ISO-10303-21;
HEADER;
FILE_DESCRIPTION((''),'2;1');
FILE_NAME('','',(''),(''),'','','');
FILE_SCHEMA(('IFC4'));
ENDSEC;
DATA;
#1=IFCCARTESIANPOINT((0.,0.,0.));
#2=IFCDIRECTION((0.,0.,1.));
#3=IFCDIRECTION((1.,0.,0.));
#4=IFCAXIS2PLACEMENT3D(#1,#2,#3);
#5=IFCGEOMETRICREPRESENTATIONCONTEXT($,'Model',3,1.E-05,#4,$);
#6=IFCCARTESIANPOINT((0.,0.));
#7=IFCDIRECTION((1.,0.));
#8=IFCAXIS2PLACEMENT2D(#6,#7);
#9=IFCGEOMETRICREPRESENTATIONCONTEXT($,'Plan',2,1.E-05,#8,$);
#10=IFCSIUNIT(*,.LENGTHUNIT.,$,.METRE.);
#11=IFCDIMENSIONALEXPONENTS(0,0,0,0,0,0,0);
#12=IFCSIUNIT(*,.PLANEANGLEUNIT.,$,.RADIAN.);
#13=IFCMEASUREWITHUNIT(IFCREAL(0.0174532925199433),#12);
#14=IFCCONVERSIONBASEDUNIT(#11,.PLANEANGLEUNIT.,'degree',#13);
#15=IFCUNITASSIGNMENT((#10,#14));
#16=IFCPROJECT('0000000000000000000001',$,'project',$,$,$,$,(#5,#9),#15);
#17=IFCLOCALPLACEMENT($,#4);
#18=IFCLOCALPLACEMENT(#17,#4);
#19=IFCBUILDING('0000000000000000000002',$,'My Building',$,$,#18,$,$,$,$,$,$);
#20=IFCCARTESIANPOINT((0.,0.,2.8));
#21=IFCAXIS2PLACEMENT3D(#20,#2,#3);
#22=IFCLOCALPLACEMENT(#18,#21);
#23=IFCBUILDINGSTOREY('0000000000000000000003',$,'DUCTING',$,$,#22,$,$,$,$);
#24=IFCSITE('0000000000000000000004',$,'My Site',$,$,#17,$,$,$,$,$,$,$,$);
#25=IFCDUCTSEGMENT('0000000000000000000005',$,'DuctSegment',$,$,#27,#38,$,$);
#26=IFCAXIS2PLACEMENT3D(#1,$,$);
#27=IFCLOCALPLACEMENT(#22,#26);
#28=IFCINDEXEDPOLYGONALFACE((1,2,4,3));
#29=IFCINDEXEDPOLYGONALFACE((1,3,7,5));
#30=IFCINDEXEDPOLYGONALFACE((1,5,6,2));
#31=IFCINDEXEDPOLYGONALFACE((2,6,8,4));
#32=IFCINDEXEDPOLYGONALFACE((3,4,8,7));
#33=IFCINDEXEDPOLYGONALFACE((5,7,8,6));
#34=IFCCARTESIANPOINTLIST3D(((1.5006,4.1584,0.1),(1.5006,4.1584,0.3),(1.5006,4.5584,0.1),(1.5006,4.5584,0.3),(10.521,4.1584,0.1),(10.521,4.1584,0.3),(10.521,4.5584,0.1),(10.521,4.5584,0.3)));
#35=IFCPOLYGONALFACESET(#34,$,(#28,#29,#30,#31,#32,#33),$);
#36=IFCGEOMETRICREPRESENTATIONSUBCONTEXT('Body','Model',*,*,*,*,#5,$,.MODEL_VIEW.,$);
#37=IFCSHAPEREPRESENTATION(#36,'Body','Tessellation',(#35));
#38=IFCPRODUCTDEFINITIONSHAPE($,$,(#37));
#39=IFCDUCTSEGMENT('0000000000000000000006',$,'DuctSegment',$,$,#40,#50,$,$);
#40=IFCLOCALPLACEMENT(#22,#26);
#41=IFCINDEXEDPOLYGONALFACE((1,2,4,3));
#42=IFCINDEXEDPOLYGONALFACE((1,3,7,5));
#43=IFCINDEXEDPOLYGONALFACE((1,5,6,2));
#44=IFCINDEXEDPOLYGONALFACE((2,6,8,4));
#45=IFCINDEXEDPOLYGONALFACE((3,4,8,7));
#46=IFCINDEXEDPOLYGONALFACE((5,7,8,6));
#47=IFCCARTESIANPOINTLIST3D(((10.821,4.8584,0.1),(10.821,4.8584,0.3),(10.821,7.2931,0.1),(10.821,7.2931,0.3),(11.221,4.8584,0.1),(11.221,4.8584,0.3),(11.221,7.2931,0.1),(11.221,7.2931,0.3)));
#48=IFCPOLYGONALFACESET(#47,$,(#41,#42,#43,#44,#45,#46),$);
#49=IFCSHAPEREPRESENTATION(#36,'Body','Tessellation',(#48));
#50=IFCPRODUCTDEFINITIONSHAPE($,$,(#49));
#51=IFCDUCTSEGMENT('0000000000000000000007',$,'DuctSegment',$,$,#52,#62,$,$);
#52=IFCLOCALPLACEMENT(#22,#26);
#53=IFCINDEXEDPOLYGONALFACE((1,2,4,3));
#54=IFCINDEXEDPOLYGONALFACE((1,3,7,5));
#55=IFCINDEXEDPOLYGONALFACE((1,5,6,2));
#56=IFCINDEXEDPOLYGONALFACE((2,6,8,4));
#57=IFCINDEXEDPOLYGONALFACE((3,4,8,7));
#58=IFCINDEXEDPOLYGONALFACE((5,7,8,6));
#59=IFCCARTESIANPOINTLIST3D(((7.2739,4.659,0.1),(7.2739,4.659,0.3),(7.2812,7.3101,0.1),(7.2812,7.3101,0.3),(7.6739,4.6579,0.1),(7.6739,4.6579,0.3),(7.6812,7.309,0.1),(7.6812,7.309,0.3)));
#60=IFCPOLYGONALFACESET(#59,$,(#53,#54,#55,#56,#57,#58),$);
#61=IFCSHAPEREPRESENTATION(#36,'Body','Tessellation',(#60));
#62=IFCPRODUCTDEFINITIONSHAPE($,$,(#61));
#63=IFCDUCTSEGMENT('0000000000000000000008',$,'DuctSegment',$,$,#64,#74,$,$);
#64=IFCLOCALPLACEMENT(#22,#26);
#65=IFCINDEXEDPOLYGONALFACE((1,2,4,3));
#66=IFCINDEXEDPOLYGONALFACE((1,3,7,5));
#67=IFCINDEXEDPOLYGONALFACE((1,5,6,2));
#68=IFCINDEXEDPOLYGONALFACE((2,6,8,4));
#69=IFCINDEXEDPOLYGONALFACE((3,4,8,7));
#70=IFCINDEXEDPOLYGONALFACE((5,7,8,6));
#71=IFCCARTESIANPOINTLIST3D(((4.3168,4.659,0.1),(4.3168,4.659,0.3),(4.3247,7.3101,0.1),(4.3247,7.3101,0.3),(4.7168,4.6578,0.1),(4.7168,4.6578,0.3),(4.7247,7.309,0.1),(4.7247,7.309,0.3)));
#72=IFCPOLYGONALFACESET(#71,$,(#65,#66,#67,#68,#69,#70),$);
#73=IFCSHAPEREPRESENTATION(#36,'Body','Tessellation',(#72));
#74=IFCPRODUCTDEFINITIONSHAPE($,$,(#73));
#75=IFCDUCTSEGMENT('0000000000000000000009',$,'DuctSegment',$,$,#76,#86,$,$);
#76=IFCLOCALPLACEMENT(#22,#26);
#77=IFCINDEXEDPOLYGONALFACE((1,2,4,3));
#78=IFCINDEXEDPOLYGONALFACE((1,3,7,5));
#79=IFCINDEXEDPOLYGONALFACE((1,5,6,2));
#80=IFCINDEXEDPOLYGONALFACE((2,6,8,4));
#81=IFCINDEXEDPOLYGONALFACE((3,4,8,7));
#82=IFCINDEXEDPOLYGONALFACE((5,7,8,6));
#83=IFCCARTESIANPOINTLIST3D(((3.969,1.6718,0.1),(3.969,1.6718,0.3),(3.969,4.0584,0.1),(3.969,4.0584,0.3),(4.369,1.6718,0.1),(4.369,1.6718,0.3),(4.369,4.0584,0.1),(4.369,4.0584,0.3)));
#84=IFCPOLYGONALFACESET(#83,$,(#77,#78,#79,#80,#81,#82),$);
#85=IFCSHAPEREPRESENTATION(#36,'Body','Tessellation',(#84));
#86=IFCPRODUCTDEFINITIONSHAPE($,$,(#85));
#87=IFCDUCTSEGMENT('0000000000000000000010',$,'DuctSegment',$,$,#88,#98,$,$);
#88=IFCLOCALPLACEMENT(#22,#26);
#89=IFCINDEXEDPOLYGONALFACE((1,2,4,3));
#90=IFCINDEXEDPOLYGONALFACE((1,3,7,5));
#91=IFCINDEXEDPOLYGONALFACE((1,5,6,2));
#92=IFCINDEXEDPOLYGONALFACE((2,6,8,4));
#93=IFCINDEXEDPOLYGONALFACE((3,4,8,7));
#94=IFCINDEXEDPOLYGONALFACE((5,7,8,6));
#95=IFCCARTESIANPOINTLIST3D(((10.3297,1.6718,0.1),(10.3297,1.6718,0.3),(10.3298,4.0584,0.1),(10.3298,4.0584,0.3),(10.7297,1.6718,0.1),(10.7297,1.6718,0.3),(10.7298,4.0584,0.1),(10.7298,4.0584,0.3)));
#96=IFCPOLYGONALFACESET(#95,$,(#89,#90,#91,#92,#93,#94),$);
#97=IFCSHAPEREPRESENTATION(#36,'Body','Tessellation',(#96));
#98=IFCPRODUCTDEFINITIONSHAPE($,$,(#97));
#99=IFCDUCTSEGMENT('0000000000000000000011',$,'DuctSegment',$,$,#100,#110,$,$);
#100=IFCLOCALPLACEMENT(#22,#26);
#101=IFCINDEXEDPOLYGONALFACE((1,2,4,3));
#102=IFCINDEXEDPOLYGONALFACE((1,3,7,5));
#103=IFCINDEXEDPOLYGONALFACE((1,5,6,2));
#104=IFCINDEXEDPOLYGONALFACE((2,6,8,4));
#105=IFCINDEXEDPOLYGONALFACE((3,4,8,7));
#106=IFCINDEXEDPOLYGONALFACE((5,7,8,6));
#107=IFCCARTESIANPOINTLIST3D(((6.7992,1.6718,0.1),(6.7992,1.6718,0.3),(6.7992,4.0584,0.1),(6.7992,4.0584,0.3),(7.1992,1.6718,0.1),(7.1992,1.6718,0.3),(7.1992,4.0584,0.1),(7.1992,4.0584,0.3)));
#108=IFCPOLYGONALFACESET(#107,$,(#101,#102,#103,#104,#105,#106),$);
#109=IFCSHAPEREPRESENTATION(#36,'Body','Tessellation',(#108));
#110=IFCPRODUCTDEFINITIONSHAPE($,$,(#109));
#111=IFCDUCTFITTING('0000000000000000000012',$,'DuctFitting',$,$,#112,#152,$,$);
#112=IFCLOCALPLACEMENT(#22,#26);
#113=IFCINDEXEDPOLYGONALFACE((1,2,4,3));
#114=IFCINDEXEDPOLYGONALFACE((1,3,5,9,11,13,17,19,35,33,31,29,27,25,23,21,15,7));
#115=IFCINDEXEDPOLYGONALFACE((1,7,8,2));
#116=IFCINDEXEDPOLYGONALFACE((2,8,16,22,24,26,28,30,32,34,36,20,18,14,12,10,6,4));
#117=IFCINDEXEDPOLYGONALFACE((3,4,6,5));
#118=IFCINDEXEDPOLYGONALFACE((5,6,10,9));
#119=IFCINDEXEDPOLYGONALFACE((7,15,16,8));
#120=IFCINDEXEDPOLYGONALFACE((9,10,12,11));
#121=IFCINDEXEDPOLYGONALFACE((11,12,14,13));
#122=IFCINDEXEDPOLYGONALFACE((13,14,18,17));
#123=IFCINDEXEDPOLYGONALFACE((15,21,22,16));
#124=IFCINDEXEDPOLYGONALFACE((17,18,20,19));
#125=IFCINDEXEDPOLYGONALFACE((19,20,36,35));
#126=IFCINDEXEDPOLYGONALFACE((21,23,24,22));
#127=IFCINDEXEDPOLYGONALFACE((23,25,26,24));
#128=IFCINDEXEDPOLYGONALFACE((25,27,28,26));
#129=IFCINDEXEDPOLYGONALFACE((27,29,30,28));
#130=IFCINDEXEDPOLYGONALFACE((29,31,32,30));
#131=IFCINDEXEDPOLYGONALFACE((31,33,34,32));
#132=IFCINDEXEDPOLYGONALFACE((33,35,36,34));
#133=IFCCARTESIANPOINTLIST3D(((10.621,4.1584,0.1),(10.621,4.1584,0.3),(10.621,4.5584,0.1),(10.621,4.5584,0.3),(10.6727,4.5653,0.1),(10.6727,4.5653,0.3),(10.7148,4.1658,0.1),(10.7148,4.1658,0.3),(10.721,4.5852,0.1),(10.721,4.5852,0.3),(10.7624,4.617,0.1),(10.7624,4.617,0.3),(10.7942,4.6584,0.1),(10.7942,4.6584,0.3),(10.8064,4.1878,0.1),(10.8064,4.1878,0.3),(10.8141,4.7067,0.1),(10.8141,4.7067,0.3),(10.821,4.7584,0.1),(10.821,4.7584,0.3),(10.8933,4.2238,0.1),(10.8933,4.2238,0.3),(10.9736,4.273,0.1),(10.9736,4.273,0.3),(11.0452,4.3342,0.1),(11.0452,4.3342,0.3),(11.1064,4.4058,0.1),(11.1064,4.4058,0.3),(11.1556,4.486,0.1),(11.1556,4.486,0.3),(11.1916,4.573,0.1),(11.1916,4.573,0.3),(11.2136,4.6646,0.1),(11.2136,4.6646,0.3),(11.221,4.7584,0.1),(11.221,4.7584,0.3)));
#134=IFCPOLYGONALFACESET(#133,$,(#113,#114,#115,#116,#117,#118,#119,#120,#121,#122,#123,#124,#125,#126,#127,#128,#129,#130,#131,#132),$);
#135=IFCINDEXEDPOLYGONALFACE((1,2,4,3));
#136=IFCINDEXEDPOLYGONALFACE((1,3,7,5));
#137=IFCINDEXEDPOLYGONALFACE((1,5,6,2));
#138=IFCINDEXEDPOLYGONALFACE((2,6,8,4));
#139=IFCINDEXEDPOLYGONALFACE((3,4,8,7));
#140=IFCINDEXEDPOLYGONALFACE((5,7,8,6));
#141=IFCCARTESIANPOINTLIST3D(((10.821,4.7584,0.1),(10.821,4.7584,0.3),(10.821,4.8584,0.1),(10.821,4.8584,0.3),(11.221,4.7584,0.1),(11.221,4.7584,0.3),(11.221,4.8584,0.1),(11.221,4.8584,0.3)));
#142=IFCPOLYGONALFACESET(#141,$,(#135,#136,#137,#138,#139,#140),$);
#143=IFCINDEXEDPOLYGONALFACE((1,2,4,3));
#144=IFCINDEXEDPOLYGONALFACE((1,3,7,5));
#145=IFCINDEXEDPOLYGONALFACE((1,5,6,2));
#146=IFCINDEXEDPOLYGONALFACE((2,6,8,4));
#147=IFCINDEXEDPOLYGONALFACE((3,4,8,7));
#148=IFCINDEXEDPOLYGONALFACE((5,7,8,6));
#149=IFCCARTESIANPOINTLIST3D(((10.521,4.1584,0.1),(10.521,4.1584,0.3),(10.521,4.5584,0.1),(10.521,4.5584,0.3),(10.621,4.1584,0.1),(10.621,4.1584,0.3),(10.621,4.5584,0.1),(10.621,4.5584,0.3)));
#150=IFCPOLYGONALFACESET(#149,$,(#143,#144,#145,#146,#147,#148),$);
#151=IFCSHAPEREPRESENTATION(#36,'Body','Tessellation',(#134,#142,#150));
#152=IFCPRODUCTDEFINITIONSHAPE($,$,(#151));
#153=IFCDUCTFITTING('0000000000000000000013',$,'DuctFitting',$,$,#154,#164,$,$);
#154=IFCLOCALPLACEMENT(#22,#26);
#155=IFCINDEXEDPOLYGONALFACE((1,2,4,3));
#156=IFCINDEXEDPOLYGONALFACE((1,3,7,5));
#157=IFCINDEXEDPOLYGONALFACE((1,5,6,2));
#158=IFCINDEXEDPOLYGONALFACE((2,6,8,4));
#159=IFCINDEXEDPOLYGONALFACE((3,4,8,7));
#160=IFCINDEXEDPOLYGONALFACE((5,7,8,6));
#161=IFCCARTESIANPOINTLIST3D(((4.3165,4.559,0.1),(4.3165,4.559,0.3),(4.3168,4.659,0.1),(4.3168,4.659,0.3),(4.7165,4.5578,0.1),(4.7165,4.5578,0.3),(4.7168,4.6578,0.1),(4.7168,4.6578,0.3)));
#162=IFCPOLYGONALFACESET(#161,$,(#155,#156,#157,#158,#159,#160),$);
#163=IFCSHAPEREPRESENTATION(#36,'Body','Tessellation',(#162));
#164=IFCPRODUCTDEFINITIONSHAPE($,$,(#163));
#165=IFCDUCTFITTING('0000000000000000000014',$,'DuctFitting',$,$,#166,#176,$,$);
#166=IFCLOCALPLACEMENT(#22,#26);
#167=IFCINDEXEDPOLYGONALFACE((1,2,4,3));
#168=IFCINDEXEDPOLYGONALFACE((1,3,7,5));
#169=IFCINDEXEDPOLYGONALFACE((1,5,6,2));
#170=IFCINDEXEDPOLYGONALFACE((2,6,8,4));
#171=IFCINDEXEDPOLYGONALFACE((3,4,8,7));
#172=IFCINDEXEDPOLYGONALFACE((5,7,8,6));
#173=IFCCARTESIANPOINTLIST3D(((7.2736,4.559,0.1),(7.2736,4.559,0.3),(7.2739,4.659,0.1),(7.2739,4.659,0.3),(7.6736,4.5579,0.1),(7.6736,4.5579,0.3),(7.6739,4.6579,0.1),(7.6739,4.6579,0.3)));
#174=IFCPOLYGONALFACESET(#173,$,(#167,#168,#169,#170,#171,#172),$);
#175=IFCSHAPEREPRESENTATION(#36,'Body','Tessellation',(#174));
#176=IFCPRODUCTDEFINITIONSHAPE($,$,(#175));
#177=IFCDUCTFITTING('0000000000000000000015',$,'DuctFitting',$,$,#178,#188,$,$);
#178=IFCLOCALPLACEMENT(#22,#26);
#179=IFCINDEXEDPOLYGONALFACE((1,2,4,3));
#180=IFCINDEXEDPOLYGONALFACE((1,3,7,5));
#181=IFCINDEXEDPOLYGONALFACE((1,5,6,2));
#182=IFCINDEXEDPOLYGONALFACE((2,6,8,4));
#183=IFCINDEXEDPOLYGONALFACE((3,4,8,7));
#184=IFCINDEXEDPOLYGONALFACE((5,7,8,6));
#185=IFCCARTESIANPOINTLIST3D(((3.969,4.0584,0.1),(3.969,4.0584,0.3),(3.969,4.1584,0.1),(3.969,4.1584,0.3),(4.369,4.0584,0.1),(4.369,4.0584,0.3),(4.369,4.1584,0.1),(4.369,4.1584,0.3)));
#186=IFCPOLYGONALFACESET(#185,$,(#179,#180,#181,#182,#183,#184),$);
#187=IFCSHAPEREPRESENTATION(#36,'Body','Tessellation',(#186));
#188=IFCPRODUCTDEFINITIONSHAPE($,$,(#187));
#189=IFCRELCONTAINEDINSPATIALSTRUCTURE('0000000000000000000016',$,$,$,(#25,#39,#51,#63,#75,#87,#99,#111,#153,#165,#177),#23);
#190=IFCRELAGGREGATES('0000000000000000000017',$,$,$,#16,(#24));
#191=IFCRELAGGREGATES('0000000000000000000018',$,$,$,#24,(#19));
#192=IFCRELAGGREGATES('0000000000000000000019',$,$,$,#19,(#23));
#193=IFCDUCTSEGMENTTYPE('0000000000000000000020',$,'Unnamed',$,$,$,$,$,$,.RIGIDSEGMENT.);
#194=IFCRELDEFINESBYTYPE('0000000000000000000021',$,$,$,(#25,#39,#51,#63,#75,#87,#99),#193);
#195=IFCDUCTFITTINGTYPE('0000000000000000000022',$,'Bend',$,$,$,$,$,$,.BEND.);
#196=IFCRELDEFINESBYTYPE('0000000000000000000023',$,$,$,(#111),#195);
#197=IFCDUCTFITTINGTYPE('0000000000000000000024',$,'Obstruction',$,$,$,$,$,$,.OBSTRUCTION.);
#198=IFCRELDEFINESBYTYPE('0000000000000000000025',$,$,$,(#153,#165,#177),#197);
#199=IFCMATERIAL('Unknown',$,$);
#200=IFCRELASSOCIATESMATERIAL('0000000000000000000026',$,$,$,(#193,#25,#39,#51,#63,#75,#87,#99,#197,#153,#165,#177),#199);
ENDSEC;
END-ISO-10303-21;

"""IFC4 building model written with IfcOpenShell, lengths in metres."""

from ifc_helpers import new_model, entity, si_unit, converted_unit, frame, origin_with_axes, origin_2d_with_axis, place, context, subcontext, project, spatial, line, arc, indexed_curve, rectangle, outline, extrude, source, transform, mapped, material, material_profile, profile_set, profile_usage, type_object, type_shapes, element, save


model = new_model("IFC4")

# Units and contexts
model_context = context("Model", 3, precision=1e-05, world=origin_with_axes())
plan_context = context("Plan", 2, precision=1e-05, world=origin_2d_with_axis())
body_context = subcontext(model_context, "Body", "Model", "MODEL_VIEW")
ifc_project = project(units=[si_unit("LENGTHUNIT", "METRE"), converted_unit("PLANEANGLEUNIT", "degree", entity("IfcReal", 0.0174532925199433), si_unit("PLANEANGLEUNIT", "RADIAN"), dimensions=[0, 0, 0, 0, 0, 0, 0])], contexts=[model_context, plan_context])

# Site, building, storey
site_placement = place(None, origin_with_axes())
site = spatial("IfcSite", under=ifc_project, at=site_placement, Name="My Site")
building_placement = place(site_placement, origin_with_axes())
building = spatial("IfcBuilding", under=site, at=building_placement, Name="My Building")
storey_placement = place(building_placement, frame((0.0, 0.0, 2.8), z_axis=(0.0, 0.0, 1.0), x_axis=(1.0, 0.0, 0.0)))
storey = spatial("IfcBuildingStorey", under=building, at=storey_placement, Name="DUCTING")

# Duct segments
ifc_material = material(Name="Unknown")
ifc_material_profile_1 = material_profile(ifc_material, rectangle(XDim=0.4, YDim=0.2))
ifc_profile_set_1 = profile_set([ifc_material_profile_1])
ifc_profile_usage_1 = profile_usage(ifc_profile_set_1, cardinal=5)
duct_segment_type = type_object("IfcDuctSegmentType", Name="Unnamed", PredefinedType="RIGIDSEGMENT", material=ifc_profile_set_1)
duct_segment_1_placement = place(storey_placement, frame((1.5006, 4.3584, 0.2), z_axis=(1.0, 0.000005, 0.0), x_axis=(-0.000005, 1.0, 0.0)))
element("IfcDuctSegment", 1, at=duct_segment_1_placement, inside=storey, type_object=duct_segment_type, material=ifc_profile_usage_1, Name="DuctSegment", context=body_context, shape_type="SweptSolid", body=[
    extrude(rectangle(XDim=0.4, YDim=0.2), origin_with_axes(), (0.0, 0.0, 1.0), 9.0204),
])
ifc_profile_usage_2 = profile_usage(ifc_profile_set_1, cardinal=5)
duct_segment_2_placement = place(storey_placement, frame((11.021, 4.8584, 0.2), z_axis=(0.0, 1.0, 0.0), x_axis=(-1.0, 0.0, 0.0)))
element("IfcDuctSegment", 2, at=duct_segment_2_placement, inside=storey, type_object=duct_segment_type, material=ifc_profile_usage_2, Name="DuctSegment", context=body_context, shape_type="SweptSolid", body=[
    extrude(rectangle(XDim=0.4, YDim=0.2), origin_with_axes(), (0.0, 0.0, 1.0), 2.4347),
])
ifc_profile_usage_3 = profile_usage(ifc_profile_set_1, cardinal=5)
duct_segment_3_placement = place(storey_placement, frame((7.4739, 4.6584, 0.2), z_axis=(0.002762, 0.999996, 0.0), x_axis=(-0.999996, 0.002762, 0.0)))
element("IfcDuctSegment", 3, at=duct_segment_3_placement, inside=storey, type_object=duct_segment_type, material=ifc_profile_usage_3, Name="DuctSegment", context=body_context, shape_type="SweptSolid", body=[
    extrude(rectangle(XDim=0.4, YDim=0.2), origin_with_axes(), (0.0, 0.0, 1.0), 2.6511),
])
ifc_profile_usage_4 = profile_usage(ifc_profile_set_1, cardinal=5)
duct_segment_4_placement = place(storey_placement, frame((4.5168, 4.6584, 0.2), z_axis=(0.00297, 0.999996, 0.0), x_axis=(-0.999996, 0.00297, 0.0)))
element("IfcDuctSegment", 4, at=duct_segment_4_placement, inside=storey, type_object=duct_segment_type, material=ifc_profile_usage_4, Name="DuctSegment", context=body_context, shape_type="SweptSolid", body=[
    extrude(rectangle(XDim=0.4, YDim=0.2), origin_with_axes(), (0.0, 0.0, 1.0), 2.6511),
])
ifc_profile_usage_5 = profile_usage(ifc_profile_set_1, cardinal=5)
duct_segment_5_placement = place(storey_placement, frame((4.169, 4.0584, 0.2), z_axis=(-0.000025, -1.0, 0.0), x_axis=(1.0, -0.000025, 0.0)))
element("IfcDuctSegment", 5, at=duct_segment_5_placement, inside=storey, type_object=duct_segment_type, material=ifc_profile_usage_5, Name="DuctSegment", context=body_context, shape_type="SweptSolid", body=[
    extrude(rectangle(XDim=0.4, YDim=0.2), origin_with_axes(), (0.0, 0.0, 1.0), 2.3866),
])
ifc_profile_usage_6 = profile_usage(ifc_profile_set_1, cardinal=5)
duct_segment_6_placement = place(storey_placement, frame((10.5298, 4.0584, 0.2), z_axis=(-0.000025, -1.0, 0.0), x_axis=(1.0, -0.000025, 0.0)))
element("IfcDuctSegment", 6, at=duct_segment_6_placement, inside=storey, type_object=duct_segment_type, material=ifc_profile_usage_6, Name="DuctSegment", context=body_context, shape_type="SweptSolid", body=[
    extrude(rectangle(XDim=0.4, YDim=0.2), origin_with_axes(), (0.0, 0.0, 1.0), 2.3866),
])
ifc_profile_usage_7 = profile_usage(ifc_profile_set_1, cardinal=5)
duct_segment_7_placement = place(storey_placement, frame((6.9992, 4.0584, 0.2), z_axis=(-0.000025, -1.0, 0.0), x_axis=(1.0, -0.000025, 0.0)))
element("IfcDuctSegment", 7, at=duct_segment_7_placement, inside=storey, type_object=duct_segment_type, material=ifc_profile_usage_7, Name="DuctSegment", context=body_context, shape_type="SweptSolid", body=[
    extrude(rectangle(XDim=0.4, YDim=0.2), origin_with_axes(), (0.0, 0.0, 1.0), 2.3866),
])

# Duct fittings
duct_fitting_type_1 = type_object("IfcDuctFittingType", Name="Bend", PredefinedType="BEND")
shared_shape = source(origin_with_axes(), body_context, "Body", "SweptSolid", [
    extrude(outline(indexed_curve([(0.2, 0.0), (0.2586, -0.1414), (0.4, -0.2), (0.4, -0.6), (-0.0243, -0.4243), (-0.2, 0.0)], segments=[arc(1, 2, 3), line(3, 4), arc(4, 5, 6), line(6, 1)])), frame((0.0, -0.1, -0.1), z_axis=(0.0, -1.0, 0.0), x_axis=(1.0, 0.0, 0.0)), (0.0, 0.0, -1.0), 0.2),
    extrude(rectangle(XDim=0.4, YDim=0.2), origin_with_axes(), (0.0, 0.0, -1.0), 0.1),
    extrude(rectangle(XDim=0.4, YDim=0.2), frame((0.4, 0.0, -0.5), z_axis=(1.0, 0.0, -0.000005), x_axis=(0.000005, 0.0, 1.0)), (0.0, 0.0, 1.0), 0.1),
])
type_shapes(duct_fitting_type_1, [shared_shape])
duct_fitting_1_placement = place(storey_placement, frame((11.021, 4.8584, 0.2), z_axis=(0.0, 1.0, 0.0), x_axis=(-1.0, 0.0, 0.0)))
element("IfcDuctFitting", 8, at=duct_fitting_1_placement, inside=storey, type_object=duct_fitting_type_1, Name="DuctFitting", context=body_context, shape_type="MappedRepresentation", body=[
    mapped(shared_shape, transform((0.0, 0.0, 0.0), x_axis=(1.0, 0.0, 0.0), y_axis=(0.0, 1.0, 0.0), z_axis=(0.0, 0.0, 1.0), scale=1.0)),
])
ifc_material_profile_2 = material_profile(ifc_material, rectangle(XDim=0.4, YDim=0.2))
ifc_profile_set_2 = profile_set([ifc_material_profile_2])
ifc_profile_usage_8 = profile_usage(ifc_profile_set_2, cardinal=5)
duct_fitting_type_2 = type_object("IfcDuctFittingType", Name="Obstruction", PredefinedType="OBSTRUCTION", material=ifc_profile_set_2)
duct_fitting_2_placement = place(storey_placement, frame((4.5165, 4.5584, 0.2), z_axis=(0.00297, 0.999996, 0.0), x_axis=(-0.999996, 0.00297, 0.0)))
element("IfcDuctFitting", 9, at=duct_fitting_2_placement, inside=storey, type_object=duct_fitting_type_2, material=ifc_profile_usage_8, Name="DuctFitting", context=body_context, shape_type="SweptSolid", body=[
    extrude(rectangle(XDim=0.4, YDim=0.2), origin_with_axes(), (0.0, 0.0, 1.0), 0.1),
])
ifc_profile_usage_9 = profile_usage(ifc_profile_set_2, cardinal=5)
duct_fitting_3_placement = place(storey_placement, frame((7.4736, 4.5584, 0.2), z_axis=(0.002762, 0.999996, 0.0), x_axis=(-0.999996, 0.002762, 0.0)))
element("IfcDuctFitting", 10, at=duct_fitting_3_placement, inside=storey, type_object=duct_fitting_type_2, material=ifc_profile_usage_9, Name="DuctFitting", context=body_context, shape_type="SweptSolid", body=[
    extrude(rectangle(XDim=0.4, YDim=0.2), origin_with_axes(), (0.0, 0.0, 1.0), 0.1),
])
ifc_profile_usage_10 = profile_usage(ifc_profile_set_2, cardinal=5)
duct_fitting_4_placement = place(storey_placement, frame((4.169, 4.1584, 0.2), z_axis=(-0.000025, -1.0, 0.0), x_axis=(1.0, -0.000025, 0.0)))
element("IfcDuctFitting", 11, at=duct_fitting_4_placement, inside=storey, type_object=duct_fitting_type_2, material=ifc_profile_usage_10, Name="DuctFitting", context=body_context, shape_type="SweptSolid", body=[
    extrude(rectangle(XDim=0.4, YDim=0.2), origin_with_axes(), (0.0, 0.0, 1.0), 0.1),
])

save(model, "model.ifc")
